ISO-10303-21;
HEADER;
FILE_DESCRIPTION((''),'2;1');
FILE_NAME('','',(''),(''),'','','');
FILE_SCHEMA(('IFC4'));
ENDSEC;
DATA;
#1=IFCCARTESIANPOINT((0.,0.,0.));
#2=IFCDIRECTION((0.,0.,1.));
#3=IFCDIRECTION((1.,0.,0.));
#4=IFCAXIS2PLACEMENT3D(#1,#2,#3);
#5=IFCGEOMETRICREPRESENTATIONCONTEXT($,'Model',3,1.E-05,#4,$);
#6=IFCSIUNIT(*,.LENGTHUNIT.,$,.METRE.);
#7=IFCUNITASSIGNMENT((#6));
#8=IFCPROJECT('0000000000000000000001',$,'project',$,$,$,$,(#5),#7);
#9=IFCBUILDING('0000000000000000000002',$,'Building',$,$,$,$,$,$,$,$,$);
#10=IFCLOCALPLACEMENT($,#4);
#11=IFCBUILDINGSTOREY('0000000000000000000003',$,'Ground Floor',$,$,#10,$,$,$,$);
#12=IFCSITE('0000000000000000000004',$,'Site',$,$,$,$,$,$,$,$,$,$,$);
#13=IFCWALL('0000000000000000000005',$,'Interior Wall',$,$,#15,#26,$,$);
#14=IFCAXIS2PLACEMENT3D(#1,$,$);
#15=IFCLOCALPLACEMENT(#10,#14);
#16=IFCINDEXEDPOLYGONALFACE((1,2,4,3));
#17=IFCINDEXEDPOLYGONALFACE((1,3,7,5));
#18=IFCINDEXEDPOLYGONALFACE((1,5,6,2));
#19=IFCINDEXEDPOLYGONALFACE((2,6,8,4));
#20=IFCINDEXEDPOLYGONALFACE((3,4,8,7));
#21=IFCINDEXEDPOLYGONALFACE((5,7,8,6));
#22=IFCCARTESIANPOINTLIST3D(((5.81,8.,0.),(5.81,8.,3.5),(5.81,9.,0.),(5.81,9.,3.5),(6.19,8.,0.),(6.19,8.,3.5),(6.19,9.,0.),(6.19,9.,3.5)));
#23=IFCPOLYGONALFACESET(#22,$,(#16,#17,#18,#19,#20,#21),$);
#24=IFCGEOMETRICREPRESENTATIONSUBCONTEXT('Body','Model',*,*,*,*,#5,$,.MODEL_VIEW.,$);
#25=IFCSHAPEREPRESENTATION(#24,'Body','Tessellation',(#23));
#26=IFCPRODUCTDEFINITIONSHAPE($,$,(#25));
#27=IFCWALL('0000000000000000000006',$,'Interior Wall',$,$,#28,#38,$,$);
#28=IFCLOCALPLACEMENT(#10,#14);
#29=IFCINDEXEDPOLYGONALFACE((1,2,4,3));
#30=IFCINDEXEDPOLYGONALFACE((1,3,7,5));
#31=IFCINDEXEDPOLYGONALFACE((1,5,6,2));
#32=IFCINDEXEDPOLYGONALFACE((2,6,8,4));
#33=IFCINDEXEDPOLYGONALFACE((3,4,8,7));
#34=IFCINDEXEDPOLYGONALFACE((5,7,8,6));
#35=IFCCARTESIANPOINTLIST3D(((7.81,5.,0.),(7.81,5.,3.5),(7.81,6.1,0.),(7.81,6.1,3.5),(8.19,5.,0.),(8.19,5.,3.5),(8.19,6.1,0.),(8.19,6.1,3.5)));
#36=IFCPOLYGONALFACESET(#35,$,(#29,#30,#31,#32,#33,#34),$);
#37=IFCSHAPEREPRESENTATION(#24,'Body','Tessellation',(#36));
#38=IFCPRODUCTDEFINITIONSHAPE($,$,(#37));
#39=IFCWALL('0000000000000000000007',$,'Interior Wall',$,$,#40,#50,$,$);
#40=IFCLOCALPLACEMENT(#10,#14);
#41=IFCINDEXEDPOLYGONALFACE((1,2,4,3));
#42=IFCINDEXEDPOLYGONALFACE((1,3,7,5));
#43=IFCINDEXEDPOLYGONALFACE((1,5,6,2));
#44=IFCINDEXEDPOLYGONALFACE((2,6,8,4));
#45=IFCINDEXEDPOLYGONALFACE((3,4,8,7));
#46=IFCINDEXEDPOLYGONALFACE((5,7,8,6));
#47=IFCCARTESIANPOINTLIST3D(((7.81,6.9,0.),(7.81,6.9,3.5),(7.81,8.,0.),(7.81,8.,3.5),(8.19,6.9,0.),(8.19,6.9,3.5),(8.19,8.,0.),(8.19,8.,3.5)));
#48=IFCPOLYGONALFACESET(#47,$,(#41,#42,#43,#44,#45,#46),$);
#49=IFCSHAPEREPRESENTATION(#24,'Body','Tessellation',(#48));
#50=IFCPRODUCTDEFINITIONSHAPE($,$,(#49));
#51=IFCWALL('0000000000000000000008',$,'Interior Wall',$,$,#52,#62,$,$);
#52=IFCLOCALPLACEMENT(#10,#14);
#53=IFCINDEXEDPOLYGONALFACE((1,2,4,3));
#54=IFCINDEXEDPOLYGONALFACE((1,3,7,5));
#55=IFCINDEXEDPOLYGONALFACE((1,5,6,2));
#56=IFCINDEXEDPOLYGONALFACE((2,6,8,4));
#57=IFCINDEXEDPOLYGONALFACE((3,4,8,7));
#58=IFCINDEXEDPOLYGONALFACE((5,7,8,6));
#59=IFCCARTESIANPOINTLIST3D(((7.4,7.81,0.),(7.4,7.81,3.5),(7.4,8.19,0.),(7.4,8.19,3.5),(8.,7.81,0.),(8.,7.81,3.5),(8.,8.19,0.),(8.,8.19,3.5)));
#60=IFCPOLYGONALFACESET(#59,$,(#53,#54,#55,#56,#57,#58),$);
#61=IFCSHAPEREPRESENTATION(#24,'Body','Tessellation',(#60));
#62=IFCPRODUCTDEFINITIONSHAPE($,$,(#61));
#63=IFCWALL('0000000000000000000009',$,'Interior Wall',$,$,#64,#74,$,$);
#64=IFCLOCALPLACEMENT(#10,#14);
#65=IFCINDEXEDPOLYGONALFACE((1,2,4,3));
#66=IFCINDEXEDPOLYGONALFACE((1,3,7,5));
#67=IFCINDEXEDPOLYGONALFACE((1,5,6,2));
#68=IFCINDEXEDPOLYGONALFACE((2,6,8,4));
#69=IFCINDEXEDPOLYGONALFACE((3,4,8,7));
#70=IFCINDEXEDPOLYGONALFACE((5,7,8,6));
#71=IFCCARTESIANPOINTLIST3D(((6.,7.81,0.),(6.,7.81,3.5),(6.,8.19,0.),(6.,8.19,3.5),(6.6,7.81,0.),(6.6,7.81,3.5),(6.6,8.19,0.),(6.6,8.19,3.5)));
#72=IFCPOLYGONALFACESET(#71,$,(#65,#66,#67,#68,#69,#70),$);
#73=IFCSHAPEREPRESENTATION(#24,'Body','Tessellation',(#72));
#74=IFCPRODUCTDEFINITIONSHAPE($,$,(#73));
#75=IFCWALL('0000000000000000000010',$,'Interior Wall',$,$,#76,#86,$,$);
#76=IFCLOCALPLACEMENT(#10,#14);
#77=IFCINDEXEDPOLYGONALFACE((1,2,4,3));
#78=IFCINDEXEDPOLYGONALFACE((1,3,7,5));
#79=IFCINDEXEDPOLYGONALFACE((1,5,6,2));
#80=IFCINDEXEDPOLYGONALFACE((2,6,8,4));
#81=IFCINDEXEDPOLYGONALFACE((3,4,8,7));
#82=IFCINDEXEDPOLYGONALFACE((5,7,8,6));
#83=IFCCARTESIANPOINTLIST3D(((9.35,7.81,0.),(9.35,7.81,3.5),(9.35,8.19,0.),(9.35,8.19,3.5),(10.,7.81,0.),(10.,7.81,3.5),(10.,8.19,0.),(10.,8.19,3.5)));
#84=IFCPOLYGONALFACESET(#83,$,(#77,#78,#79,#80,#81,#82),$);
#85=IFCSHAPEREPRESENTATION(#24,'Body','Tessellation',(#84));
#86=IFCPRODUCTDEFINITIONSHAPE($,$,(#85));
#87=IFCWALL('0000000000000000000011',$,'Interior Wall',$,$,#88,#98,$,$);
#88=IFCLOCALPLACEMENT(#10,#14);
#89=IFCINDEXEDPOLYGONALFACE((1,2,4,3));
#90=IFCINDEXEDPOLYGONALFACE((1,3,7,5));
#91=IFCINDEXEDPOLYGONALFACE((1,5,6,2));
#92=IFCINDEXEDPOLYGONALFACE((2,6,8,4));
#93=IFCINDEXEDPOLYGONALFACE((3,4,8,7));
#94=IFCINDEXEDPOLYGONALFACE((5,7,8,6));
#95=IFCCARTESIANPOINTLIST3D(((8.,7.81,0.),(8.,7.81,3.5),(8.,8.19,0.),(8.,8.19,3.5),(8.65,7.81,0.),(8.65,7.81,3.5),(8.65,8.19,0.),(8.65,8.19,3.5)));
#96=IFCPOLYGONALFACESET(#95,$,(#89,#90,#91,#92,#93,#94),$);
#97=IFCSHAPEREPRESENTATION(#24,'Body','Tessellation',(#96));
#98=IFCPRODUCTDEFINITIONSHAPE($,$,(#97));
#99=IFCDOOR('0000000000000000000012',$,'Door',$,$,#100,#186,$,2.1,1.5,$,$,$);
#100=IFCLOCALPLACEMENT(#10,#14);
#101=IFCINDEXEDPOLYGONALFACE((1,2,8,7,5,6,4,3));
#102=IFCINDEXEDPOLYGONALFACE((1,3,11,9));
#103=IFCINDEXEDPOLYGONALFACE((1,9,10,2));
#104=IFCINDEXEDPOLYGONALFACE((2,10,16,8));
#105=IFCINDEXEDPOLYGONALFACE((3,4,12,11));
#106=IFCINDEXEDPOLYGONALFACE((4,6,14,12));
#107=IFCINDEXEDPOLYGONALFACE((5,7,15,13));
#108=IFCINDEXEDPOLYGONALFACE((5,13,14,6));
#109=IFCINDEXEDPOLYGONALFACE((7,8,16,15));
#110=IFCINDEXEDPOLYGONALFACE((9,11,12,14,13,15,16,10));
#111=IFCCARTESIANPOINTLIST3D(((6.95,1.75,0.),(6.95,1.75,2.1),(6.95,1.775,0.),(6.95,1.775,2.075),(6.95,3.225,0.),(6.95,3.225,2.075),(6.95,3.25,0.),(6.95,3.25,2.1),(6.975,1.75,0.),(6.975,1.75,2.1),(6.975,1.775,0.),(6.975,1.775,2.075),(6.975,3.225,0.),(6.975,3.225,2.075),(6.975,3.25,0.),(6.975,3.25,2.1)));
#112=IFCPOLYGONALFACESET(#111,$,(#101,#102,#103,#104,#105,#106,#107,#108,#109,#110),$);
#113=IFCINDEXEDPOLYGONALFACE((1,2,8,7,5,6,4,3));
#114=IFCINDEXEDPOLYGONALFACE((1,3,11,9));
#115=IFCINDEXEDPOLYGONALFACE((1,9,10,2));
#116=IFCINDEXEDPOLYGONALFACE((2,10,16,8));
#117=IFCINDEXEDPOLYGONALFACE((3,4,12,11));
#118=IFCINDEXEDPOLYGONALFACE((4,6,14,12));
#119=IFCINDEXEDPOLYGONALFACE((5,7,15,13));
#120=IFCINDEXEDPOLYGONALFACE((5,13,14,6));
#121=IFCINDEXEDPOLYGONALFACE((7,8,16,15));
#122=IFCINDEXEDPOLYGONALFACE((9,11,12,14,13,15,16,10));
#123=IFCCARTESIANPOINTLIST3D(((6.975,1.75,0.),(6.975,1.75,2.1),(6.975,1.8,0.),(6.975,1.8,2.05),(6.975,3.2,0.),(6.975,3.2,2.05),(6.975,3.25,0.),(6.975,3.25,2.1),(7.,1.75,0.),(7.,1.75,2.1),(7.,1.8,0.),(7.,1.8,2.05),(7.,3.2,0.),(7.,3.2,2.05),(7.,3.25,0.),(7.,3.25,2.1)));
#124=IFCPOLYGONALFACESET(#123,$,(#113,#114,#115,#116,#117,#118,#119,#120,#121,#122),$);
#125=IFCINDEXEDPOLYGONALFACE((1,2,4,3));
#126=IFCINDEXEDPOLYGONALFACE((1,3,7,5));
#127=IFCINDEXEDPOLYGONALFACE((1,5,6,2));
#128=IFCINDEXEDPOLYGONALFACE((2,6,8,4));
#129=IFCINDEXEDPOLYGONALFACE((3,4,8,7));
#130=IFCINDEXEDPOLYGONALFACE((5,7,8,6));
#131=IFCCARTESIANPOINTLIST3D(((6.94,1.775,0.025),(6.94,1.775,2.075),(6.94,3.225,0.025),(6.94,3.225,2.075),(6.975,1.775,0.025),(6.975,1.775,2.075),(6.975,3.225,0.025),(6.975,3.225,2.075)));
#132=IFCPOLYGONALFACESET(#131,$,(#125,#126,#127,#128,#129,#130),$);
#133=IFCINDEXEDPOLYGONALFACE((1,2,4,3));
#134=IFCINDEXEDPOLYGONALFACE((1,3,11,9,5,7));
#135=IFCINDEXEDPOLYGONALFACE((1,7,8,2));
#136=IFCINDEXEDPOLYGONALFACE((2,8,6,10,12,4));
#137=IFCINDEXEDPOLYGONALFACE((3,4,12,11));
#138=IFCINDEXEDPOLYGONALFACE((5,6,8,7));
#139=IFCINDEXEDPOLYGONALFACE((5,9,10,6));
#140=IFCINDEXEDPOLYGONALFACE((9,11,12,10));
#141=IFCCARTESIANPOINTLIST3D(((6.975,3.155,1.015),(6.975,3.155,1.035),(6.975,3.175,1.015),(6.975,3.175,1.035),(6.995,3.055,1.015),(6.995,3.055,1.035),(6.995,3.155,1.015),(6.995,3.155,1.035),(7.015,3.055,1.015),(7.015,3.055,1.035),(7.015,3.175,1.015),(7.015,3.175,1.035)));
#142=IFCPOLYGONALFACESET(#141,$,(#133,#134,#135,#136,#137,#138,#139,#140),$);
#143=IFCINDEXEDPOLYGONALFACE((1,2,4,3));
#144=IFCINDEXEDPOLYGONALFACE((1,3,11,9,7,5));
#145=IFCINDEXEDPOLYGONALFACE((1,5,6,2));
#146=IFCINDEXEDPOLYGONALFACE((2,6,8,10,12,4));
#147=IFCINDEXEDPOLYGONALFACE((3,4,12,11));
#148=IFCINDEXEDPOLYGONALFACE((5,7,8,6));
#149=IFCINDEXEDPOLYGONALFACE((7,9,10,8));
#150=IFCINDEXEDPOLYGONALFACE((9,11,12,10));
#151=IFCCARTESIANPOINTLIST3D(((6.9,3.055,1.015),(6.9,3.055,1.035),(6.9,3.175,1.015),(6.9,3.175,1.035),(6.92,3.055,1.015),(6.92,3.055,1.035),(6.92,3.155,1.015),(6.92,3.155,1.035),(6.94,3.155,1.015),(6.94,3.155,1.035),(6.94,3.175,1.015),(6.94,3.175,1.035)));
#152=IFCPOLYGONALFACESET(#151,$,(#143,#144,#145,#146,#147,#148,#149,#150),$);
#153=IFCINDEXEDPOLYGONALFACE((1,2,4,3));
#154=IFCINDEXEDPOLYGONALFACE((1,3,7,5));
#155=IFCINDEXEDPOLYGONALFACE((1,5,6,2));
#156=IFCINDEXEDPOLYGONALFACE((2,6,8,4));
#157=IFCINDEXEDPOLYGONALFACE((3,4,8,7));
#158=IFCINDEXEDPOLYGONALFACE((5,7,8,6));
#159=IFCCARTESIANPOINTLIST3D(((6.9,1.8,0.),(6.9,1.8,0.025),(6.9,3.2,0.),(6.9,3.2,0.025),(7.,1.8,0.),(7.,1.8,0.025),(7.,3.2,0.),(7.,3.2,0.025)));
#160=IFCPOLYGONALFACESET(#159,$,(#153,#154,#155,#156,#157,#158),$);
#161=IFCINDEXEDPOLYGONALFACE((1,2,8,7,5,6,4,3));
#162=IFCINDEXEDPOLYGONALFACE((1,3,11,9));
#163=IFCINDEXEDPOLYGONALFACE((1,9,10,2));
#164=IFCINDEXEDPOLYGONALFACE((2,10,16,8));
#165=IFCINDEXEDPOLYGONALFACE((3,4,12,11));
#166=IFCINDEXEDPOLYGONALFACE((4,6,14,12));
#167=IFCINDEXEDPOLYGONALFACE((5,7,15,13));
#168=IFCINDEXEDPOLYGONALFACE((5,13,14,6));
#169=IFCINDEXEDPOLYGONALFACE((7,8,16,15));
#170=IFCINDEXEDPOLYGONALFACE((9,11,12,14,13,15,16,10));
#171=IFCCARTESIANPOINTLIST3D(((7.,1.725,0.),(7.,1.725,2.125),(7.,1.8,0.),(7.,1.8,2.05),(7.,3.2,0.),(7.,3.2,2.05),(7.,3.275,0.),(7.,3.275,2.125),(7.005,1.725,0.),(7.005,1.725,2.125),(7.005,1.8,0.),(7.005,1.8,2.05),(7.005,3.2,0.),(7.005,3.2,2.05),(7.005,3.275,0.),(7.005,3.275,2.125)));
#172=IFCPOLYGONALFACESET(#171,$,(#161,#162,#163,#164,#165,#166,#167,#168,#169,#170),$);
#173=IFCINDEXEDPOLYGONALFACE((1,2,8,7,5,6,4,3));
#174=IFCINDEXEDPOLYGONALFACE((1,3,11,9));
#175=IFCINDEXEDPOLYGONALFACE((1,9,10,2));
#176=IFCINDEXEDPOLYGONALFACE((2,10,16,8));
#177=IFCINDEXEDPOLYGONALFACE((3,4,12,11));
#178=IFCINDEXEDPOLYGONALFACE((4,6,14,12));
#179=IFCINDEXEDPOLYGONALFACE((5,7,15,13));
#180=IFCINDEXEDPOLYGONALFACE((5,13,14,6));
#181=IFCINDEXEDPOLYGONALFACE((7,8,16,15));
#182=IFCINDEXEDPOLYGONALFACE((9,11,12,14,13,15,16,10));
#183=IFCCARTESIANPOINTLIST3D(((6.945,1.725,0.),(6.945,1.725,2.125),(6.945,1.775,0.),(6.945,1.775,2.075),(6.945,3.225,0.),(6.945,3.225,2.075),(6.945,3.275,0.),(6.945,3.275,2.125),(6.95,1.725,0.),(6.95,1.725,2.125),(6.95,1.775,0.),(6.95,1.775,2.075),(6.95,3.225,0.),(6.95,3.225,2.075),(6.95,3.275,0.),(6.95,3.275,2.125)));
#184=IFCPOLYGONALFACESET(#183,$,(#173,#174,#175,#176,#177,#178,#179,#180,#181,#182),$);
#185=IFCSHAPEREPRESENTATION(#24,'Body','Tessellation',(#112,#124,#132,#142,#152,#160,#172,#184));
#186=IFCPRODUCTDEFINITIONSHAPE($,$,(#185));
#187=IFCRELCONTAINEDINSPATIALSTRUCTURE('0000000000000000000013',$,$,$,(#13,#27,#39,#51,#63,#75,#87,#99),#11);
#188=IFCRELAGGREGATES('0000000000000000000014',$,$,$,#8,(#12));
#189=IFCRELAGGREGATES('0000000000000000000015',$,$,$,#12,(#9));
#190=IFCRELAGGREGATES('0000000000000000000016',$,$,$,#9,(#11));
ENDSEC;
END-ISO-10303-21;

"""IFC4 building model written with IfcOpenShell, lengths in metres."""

from ifc_helpers import new_model, si_unit, frame, origin_with_axes, place, context, subcontext, project, spatial, line, indexed_curve, outline, extrude, element, save


model = new_model("IFC4")

# Units and contexts
model_context = context("Model", 3, precision=1e-05, world=origin_with_axes())
body_context = subcontext(model_context, "Body", "Model", "MODEL_VIEW")
ifc_project = project(units=[si_unit("LENGTHUNIT", "METRE")], contexts=[model_context])

# Site, building, storey
site = spatial("IfcSite", under=ifc_project, Name="Site")
building = spatial("IfcBuilding", under=site, Name="Building")
storey_placement = place(None, origin_with_axes())
storey = spatial("IfcBuildingStorey", under=building, at=storey_placement, Name="Ground Floor")

# Walls
wall_1_placement = place(storey_placement, frame((6.0, 8.0, 0.0), z_axis=(0.0, 0.0, 1.0), x_axis=(0.0, 1.0, 0.0)))
element("IfcWall", 1, at=wall_1_placement, inside=storey, Name="Interior Wall", context=body_context, shape_type="SweptSolid", body=[
    extrude(outline(indexed_curve([(0.0, 0.0), (0.0, 0.38), (1.0, 0.38), (1.0, 0.0), (0.0, 0.0)], self_intersect=False)), frame((0.0, -0.19, 0.0), z_axis=(0.0, 0.0, 1.0), x_axis=(1.0, 0.0, 0.0)), (0.0, 0.0, 1.0), 3.5),
])
for number, where, z_axis, x_axis, name in (
    (2, (8.0, 5.0, 0.0), (0.0, 0.0, 1.0), (0.0, 1.0, 0.0), "Interior Wall"),
    (3, (8.0, 6.9, 0.0), (0.0, 0.0, 1.0), (0.0, 1.0, 0.0), "Interior Wall"),
):
    element("IfcWall", number, at=place(storey_placement, frame(where, z_axis=z_axis, x_axis=x_axis)), inside=storey, Name=name, context=body_context, shape_type="SweptSolid", body=[
        extrude(outline(indexed_curve([(0.0, 0.0), (0.0, 0.38), (1.1, 0.38), (1.1, 0.0), (0.0, 0.0)], self_intersect=False)), frame((0.0, -0.19, 0.0), z_axis=(0.0, 0.0, 1.0), x_axis=(1.0, 0.0, 0.0)), (0.0, 0.0, 1.0), 3.5),
    ])
for number, where, z_axis, x_axis, name in (
    (4, (8.0, 8.0, 0.0), (0.0, 0.0, 1.0), (-1.0, 0.0, 0.0), "Interior Wall"),
    (5, (6.6, 8.0, 0.0), (0.0, 0.0, 1.0), (-1.0, 0.0, 0.0), "Interior Wall"),
):
    element("IfcWall", number, at=place(storey_placement, frame(where, z_axis=z_axis, x_axis=x_axis)), inside=storey, Name=name, context=body_context, shape_type="SweptSolid", body=[
        extrude(outline(indexed_curve([(0.0, 0.0), (0.0, 0.38), (0.6, 0.38), (0.6, 0.0), (0.0, 0.0)], self_intersect=False)), frame((0.0, -0.19, 0.0), z_axis=(0.0, 0.0, 1.0), x_axis=(1.0, 0.0, 0.0)), (0.0, 0.0, 1.0), 3.5),
    ])
for number, where, z_axis, x_axis, name in (
    (6, (10.0, 8.0, 0.0), (0.0, 0.0, 1.0), (-1.0, 0.0, 0.0), "Interior Wall"),
    (7, (8.65, 8.0, 0.0), (0.0, 0.0, 1.0), (-1.0, 0.0, 0.0), "Interior Wall"),
):
    element("IfcWall", number, at=place(storey_placement, frame(where, z_axis=z_axis, x_axis=x_axis)), inside=storey, Name=name, context=body_context, shape_type="SweptSolid", body=[
        extrude(outline(indexed_curve([(0.0, 0.0), (0.0, 0.38), (0.65, 0.38), (0.65, 0.0), (0.0, 0.0)], self_intersect=False)), frame((0.0, -0.19, 0.0), z_axis=(0.0, 0.0, 1.0), x_axis=(1.0, 0.0, 0.0)), (0.0, 0.0, 1.0), 3.5),
    ])

# Door
door_1_placement = place(storey_placement, frame((7.0, 1.75, 0.0), z_axis=(0.0, 0.0, 1.0), x_axis=(0.0, 1.0, 0.0)))
element("IfcDoor", 8, at=door_1_placement, inside=storey, Name="Door", OverallHeight=2.1, OverallWidth=1.5, context=body_context, shape_type="SweptSolid", body=[
    extrude(outline(indexed_curve([(0.0, 0.0), (0.0, 2.1), (1.5, 2.1), (1.5, 0.0), (1.475, 0.0), (1.475, 2.075), (0.025, 2.075), (0.025, 0.0)], segments=[line(1, 2, 3, 4, 5, 6, 7, 8, 1)])), frame((0.0, 0.025, 0.0), z_axis=(0.0, -1.0, 0.0), x_axis=(1.0, 0.0, 0.0)), (0.0, 0.0, -1.0), 0.025),
    extrude(outline(indexed_curve([(0.0, 0.0), (0.0, 2.1), (1.5, 2.1), (1.5, 0.0), (1.45, 0.0), (1.45, 2.05), (0.05, 2.05), (0.05, 0.0)], segments=[line(1, 2, 3, 4, 5, 6, 7, 8, 1)])), frame((0.0, 0.0, 0.0), z_axis=(0.0, -1.0, 0.0), x_axis=(1.0, 0.0, 0.0)), (0.0, 0.0, -1.0), 0.025),
    extrude(outline(indexed_curve([(0.0, 0.0), (1.45, 0.0), (1.45, 0.035), (0.0, 0.035)], segments=[line(1, 2, 3, 4, 1)])), frame((0.025, 0.025, 0.025), z_axis=(0.0, 0.0, 1.0), x_axis=(1.0, 0.0, 0.0)), (0.0, 0.0, 1.0), 2.05),
    extrude(outline(indexed_curve([(0.0, 0.0), (0.0, -0.04), (-0.12, -0.04), (-0.12, -0.02), (-0.02, -0.02), (-0.02, 0.0)], segments=[line(1, 2, 3, 4, 5, 6, 1)])), frame((1.425, 0.025, 1.015), z_axis=(0.0, 0.0, 1.0), x_axis=(1.0, 0.0, 0.0)), (0.0, 0.0, 1.0), 0.02),
    extrude(outline(indexed_curve([(0.0, 0.0), (0.0, 0.04), (-0.12, 0.04), (-0.12, 0.02), (-0.02, 0.02), (-0.02, 0.0)], segments=[line(1, 2, 3, 4, 5, 6, 1)])), frame((1.425, 0.06, 1.015), z_axis=(0.0, 0.0, 1.0), x_axis=(1.0, 0.0, 0.0)), (0.0, 0.0, 1.0), 0.02),
    extrude(outline(indexed_curve([(0.0, 0.0), (1.4, 0.0), (1.4, 0.1), (0.0, 0.1)], segments=[line(1, 2, 3, 4, 1)])), frame((0.05, 0.0, 0.0), z_axis=(0.0, 0.0, 1.0), x_axis=(1.0, 0.0, 0.0)), (0.0, 0.0, 1.0), 0.025),
    extrude(outline(indexed_curve([(0.0, 0.0), (0.0, 2.125), (1.55, 2.125), (1.55, 0.0), (1.475, 0.0), (1.475, 2.05), (0.075, 2.05), (0.075, 0.0)], segments=[line(1, 2, 3, 4, 5, 6, 7, 8, 1)])), frame((-0.025, -0.005, 0.0), z_axis=(0.0, -1.0, 0.0), x_axis=(1.0, 0.0, 0.0)), (0.0, 0.0, -1.0), 0.005),
    extrude(outline(indexed_curve([(0.0, 0.0), (0.0, 2.125), (1.55, 2.125), (1.55, 0.0), (1.5, 0.0), (1.5, 2.075), (0.05, 2.075), (0.05, 0.0)], segments=[line(1, 2, 3, 4, 5, 6, 7, 8, 1)])), frame((-0.025, 0.05, 0.0), z_axis=(0.0, -1.0, 0.0), x_axis=(1.0, 0.0, 0.0)), (0.0, 0.0, -1.0), 0.005),
])

save(model, "model.ifc")
